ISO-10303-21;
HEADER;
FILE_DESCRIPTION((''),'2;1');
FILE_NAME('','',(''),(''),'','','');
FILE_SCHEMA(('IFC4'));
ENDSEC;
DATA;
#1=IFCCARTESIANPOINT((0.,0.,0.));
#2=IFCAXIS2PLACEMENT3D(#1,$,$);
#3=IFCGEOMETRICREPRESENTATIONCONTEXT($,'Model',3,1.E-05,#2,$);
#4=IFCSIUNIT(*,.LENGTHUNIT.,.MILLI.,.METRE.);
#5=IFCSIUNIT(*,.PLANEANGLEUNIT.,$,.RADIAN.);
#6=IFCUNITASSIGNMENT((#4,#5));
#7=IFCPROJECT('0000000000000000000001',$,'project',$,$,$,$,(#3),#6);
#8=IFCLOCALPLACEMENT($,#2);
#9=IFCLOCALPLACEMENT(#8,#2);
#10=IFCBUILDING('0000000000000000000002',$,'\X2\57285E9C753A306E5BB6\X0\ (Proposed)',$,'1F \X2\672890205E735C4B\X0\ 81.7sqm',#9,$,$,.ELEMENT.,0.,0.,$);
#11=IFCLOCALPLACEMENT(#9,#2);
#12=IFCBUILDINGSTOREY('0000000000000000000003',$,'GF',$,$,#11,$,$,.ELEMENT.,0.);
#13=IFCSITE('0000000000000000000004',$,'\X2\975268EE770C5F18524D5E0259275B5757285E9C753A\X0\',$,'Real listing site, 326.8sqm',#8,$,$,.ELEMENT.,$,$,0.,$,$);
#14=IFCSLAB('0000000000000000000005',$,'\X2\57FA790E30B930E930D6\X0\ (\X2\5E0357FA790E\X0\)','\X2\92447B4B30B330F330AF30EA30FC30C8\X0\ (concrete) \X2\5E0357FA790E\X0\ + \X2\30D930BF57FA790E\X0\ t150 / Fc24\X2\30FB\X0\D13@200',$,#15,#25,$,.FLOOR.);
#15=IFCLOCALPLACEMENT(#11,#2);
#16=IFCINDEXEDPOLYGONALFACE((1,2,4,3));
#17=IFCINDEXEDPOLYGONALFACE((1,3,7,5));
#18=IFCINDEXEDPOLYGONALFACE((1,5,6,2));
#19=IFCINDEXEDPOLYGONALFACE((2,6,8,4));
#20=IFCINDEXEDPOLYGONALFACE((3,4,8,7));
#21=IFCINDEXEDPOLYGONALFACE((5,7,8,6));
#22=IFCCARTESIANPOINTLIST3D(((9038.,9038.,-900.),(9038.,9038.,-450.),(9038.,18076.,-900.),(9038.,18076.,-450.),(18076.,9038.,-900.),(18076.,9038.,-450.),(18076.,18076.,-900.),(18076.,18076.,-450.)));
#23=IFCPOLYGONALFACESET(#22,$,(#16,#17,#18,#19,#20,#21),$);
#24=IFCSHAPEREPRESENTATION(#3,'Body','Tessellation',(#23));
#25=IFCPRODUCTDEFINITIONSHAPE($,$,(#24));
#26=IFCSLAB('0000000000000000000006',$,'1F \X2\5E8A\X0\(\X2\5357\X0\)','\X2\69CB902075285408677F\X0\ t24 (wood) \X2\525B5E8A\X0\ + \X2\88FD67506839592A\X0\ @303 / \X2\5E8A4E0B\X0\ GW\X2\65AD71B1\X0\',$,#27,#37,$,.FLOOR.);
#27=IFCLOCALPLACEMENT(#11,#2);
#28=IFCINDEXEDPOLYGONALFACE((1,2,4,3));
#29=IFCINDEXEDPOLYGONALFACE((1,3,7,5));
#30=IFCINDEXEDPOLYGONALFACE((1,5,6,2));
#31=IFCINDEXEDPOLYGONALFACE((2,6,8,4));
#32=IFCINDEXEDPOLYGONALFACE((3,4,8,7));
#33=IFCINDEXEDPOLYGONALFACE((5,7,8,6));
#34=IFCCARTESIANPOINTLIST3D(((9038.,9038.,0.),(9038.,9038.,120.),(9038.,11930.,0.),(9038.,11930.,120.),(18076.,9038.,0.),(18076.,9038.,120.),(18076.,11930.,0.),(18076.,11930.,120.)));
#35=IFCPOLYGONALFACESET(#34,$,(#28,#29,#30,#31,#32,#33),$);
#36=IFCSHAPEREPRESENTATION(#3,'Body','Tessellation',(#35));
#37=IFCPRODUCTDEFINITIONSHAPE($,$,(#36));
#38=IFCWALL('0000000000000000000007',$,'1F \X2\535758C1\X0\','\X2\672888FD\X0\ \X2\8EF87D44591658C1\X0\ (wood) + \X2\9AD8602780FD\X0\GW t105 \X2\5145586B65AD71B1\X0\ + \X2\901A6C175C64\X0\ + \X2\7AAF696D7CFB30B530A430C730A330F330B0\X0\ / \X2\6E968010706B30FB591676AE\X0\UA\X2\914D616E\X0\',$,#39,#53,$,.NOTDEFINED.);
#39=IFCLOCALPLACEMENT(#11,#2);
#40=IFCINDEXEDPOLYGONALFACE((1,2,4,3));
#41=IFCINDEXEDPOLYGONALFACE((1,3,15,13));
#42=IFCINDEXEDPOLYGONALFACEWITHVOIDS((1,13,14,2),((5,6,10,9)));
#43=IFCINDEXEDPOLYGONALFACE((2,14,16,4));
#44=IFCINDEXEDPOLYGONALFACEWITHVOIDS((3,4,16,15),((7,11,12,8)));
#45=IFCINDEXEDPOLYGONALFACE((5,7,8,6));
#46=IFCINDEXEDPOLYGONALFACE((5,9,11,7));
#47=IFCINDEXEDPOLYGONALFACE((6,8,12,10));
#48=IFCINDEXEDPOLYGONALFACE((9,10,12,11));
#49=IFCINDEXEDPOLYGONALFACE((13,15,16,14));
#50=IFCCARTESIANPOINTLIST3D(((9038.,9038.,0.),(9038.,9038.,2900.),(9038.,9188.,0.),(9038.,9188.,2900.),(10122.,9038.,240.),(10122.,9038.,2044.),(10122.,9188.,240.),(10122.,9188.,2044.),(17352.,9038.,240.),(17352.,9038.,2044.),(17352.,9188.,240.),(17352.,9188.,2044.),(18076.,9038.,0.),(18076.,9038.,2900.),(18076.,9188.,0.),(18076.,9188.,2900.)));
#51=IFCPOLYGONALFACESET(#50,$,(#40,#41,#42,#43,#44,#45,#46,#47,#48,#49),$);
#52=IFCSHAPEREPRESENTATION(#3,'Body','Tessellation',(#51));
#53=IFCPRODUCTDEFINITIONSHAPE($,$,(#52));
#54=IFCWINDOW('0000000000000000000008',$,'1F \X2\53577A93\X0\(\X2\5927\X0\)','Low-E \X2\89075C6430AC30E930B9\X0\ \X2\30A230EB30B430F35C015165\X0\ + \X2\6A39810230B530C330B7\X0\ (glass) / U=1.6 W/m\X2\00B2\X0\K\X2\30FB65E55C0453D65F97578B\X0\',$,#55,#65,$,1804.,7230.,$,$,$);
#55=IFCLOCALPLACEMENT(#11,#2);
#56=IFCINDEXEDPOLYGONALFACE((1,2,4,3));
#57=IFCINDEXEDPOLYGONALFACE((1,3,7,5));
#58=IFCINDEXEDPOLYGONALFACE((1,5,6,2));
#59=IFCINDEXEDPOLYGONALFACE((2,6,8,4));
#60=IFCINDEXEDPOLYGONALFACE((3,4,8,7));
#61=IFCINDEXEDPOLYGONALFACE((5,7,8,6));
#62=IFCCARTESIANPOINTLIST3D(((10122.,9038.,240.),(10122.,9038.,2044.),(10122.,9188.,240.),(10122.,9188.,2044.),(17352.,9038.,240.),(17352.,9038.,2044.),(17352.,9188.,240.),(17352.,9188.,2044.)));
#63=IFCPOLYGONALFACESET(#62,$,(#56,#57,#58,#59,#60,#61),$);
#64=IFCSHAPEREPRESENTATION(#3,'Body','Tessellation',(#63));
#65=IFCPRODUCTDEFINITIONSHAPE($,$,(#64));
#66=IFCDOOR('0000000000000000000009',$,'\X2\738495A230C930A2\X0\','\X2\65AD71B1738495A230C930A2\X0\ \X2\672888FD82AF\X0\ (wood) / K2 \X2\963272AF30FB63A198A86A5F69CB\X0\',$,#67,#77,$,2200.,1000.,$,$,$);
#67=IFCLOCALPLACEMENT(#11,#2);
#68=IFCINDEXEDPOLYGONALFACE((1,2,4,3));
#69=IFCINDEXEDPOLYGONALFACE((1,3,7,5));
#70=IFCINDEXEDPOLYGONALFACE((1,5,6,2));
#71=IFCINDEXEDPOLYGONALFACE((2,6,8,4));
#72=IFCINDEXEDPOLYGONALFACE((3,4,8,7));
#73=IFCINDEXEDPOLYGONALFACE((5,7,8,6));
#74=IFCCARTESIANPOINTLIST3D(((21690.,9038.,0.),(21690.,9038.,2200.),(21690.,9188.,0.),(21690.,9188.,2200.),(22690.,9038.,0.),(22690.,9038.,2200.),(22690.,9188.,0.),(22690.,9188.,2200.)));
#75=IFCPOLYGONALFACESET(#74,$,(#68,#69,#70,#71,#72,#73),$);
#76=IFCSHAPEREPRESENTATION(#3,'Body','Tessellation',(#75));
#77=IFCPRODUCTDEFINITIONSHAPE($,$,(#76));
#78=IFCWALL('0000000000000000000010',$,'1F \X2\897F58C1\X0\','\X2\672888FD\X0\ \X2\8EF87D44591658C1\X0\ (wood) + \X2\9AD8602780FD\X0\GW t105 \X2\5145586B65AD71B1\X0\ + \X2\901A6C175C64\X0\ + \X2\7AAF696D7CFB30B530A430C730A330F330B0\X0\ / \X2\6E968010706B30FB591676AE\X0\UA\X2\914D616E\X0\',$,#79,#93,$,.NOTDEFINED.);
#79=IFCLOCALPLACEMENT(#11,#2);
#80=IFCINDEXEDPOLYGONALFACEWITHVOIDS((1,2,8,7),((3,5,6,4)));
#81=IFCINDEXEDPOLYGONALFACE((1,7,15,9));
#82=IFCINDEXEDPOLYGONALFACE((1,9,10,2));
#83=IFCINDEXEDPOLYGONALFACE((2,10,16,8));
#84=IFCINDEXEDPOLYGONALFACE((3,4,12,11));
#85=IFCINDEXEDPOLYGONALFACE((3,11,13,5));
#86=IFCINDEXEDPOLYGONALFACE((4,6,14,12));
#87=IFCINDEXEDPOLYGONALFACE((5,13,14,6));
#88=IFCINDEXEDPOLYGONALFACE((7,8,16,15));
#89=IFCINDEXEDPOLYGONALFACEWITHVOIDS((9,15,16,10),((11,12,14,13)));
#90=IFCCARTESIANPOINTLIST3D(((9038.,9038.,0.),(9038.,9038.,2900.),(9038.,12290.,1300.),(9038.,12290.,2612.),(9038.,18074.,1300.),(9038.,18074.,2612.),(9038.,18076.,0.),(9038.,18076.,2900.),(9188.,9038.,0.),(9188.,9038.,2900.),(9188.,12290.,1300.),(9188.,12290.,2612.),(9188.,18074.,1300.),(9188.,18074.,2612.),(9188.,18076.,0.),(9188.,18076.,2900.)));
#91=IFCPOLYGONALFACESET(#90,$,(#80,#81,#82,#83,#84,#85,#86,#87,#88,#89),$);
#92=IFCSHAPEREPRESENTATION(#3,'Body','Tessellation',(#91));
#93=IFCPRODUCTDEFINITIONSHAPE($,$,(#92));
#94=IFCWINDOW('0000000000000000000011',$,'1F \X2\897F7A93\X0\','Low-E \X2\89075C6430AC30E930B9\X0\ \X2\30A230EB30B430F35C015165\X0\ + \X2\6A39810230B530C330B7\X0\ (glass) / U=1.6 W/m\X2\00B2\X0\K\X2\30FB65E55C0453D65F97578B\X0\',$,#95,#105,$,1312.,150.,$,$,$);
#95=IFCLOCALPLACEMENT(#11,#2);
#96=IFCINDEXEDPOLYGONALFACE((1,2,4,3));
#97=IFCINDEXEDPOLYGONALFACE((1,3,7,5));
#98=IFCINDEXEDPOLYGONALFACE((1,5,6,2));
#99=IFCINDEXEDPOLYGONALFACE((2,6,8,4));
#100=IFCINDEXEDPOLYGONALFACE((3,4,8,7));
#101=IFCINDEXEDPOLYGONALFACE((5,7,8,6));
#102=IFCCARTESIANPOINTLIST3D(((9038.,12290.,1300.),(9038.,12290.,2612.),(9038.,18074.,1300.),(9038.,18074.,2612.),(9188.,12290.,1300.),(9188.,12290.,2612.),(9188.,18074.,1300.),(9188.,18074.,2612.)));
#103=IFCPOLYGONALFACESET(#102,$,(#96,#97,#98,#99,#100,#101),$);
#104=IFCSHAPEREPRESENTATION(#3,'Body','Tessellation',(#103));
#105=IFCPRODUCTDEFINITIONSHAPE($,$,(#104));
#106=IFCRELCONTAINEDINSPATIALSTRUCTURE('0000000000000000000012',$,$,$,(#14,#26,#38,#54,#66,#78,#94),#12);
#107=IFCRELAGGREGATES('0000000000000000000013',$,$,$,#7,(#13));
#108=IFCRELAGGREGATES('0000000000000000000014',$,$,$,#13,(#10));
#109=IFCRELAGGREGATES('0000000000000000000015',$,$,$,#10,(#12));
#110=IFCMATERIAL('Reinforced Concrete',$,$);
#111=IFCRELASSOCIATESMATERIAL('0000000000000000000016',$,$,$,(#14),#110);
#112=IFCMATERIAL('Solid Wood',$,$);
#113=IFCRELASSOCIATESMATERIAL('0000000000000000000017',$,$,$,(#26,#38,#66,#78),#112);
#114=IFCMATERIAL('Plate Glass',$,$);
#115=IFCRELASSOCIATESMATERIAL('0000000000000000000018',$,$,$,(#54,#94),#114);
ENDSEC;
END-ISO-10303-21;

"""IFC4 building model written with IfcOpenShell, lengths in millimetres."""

from ifc_helpers import new_model, si_unit, frame, frame_2d, origin, place, context, project, spatial, rectangle, extrude, material, element, fill, save


model = new_model("IFC4")

# Units and contexts
model_context = context("Model", 3, precision=1e-05, world=origin())
ifc_project = project(units=[si_unit("LENGTHUNIT", "METRE", prefix="MILLI"), si_unit("PLANEANGLEUNIT", "RADIAN")], contexts=[model_context])

# Site, building, storey
site_placement = place(None, origin())
site = spatial("IfcSite", under=ifc_project, at=site_placement, Name="青森県弘前市大字在府町", ObjectType="Real listing site, 326.8sqm", CompositionType="ELEMENT", RefElevation=0.0)
building_placement = place(site_placement, origin())
building = spatial("IfcBuilding", under=site, at=building_placement, Name="在府町の家 (Proposed)", ObjectType="1F 木造平屋 81.7sqm", CompositionType="ELEMENT", ElevationOfRefHeight=0.0, ElevationOfTerrain=0.0)
storey_placement = place(building_placement, origin())
storey = spatial("IfcBuildingStorey", under=building, at=storey_placement, Name="GF", CompositionType="ELEMENT", Elevation=0.0)

# Slabs
ifc_material_1 = material(Name="Reinforced Concrete")
slab_1_placement = place(storey_placement, frame((4519.0, 4519.0, -450.0)))
element("IfcSlab", 1, at=slab_1_placement, inside=storey, material=ifc_material_1, Name="基礎スラブ (布基礎)", Description="鉄筋コンクリート (concrete) 布基礎 + ベタ基礎 t150 / Fc24・D13@200", PredefinedType="FLOOR", context=model_context, shape_type="SweptSolid", body=[
    extrude(rectangle(XDim=9038.0, YDim=9038.0, at=frame_2d((4519.0, 4519.0))), frame((4519.0, 4519.0, -450.0)), (0.0, 0.0, 1.0), 450.0),
])
ifc_material_2 = material(Name="Solid Wood")
slab_2_placement = place(storey_placement, frame((4519.0, 4519.0, 0.0)))
element("IfcSlab", 2, at=slab_2_placement, inside=storey, material=ifc_material_2, Name="1F 床(南)", Description="構造用合板 t24 (wood) 剛床 + 製材根太 @303 / 床下 GW断熱", PredefinedType="FLOOR", context=model_context, shape_type="SweptSolid", body=[
    extrude(rectangle(XDim=9038.0, YDim=2892.0, at=frame_2d((4519.0, 1446.0))), frame((4519.0, 4519.0, 0.0)), (0.0, 0.0, 1.0), 120.0),
])

# Wall, openings, window, door
wall_1_placement = place(storey_placement, frame((4519.0, 4519.0, 0.0)))
wall_1 = element("IfcWall", 3, at=wall_1_placement, inside=storey, material=ifc_material_2, Name="1F 南壁", Description="木製 軸組外壁 (wood) + 高性能GW t105 充填断熱 + 通気層 + 窯業系サイディング / 準耐火・外皮UA配慮", PredefinedType="NOTDEFINED", context=model_context, shape_type="SweptSolid", body=[
    extrude(rectangle(XDim=9038.0, YDim=150.0, at=frame_2d((4519.0, 75.0))), frame((4519.0, 4519.0, 0.0)), (0.0, 0.0, 1.0), 2900.0),
])
opening_1_placement = place(storey_placement, frame((5061.0, 4519.0, 120.0)))
opening_1 = element("IfcOpeningElement", 4, at=opening_1_placement, cuts=wall_1, PredefinedType="NOTDEFINED", context=model_context, shape_type="SweptSolid", body=[
    extrude(rectangle(XDim=7230.0, YDim=150.0, at=frame_2d((3615.0, 75.0))), frame((5061.0, 4519.0, 120.0)), (0.0, 0.0, 1.0), 1804.0),
])
opening_2_placement = place(storey_placement, frame((10845.0, 4519.0, 0.0)))
opening_2 = element("IfcOpeningElement", 5, at=opening_2_placement, cuts=wall_1, PredefinedType="NOTDEFINED", context=model_context, shape_type="SweptSolid", body=[
    extrude(rectangle(XDim=1000.0, YDim=150.0, at=frame_2d((500.0, 75.0))), frame((10845.0, 4519.0, 0.0)), (0.0, 0.0, 1.0), 2200.0),
])
ifc_material_3 = material(Name="Plate Glass")
window_1_placement = place(storey_placement, frame((5061.0, 4519.0, 120.0)))
window_1 = element("IfcWindow", 6, at=window_1_placement, inside=storey, material=ifc_material_3, Name="1F 南窓(大)", Description="Low-E 複層ガラス アルゴン封入 + 樹脂サッシ (glass) / U=1.6 W/m²K・日射取得型", OverallHeight=1804.0, OverallWidth=7230.0, context=model_context, shape_type="SweptSolid", body=[
    extrude(rectangle(XDim=7230.0, YDim=150.0, at=frame_2d((3615.0, 75.0))), frame((5061.0, 4519.0, 120.0)), (0.0, 0.0, 1.0), 1804.0),
])
fill(opening_1, window_1)
door_1_placement = place(storey_placement, frame((10845.0, 4519.0, 0.0)))
door_1 = element("IfcDoor", 7, at=door_1_placement, inside=storey, material=ifc_material_2, Name="玄関ドア", Description="断熱玄関ドア 木製芯 (wood) / K2 防犯・採風機構", OverallHeight=2200.0, OverallWidth=1000.0, context=model_context, shape_type="SweptSolid", body=[
    extrude(rectangle(XDim=1000.0, YDim=150.0, at=frame_2d((500.0, 75.0))), frame((10845.0, 4519.0, 0.0)), (0.0, 0.0, 1.0), 2200.0),
])
fill(opening_2, door_1)

# Wall, opening, window
wall_2_placement = place(storey_placement, frame((4519.0, 4519.0, 0.0)))
wall_2 = element("IfcWall", 8, at=wall_2_placement, inside=storey, material=ifc_material_2, Name="1F 西壁", Description="木製 軸組外壁 (wood) + 高性能GW t105 充填断熱 + 通気層 + 窯業系サイディング / 準耐火・外皮UA配慮", PredefinedType="NOTDEFINED", context=model_context, shape_type="SweptSolid", body=[
    extrude(rectangle(XDim=150.0, YDim=9038.0, at=frame_2d((75.0, 4519.0))), frame((4519.0, 4519.0, 0.0)), (0.0, 0.0, 1.0), 2900.0),
])
opening_3_placement = place(storey_placement, frame((4519.0, 6145.0, 650.0)))
opening_3 = element("IfcOpeningElement", 9, at=opening_3_placement, cuts=wall_2, PredefinedType="NOTDEFINED", context=model_context, shape_type="SweptSolid", body=[
    extrude(rectangle(XDim=150.0, YDim=5784.0, at=frame_2d((75.0, 2892.0))), frame((4519.0, 6145.0, 650.0)), (0.0, 0.0, 1.0), 1312.0),
])
window_2_placement = place(storey_placement, frame((4519.0, 6145.0, 650.0)))
window_2 = element("IfcWindow", 10, at=window_2_placement, inside=storey, material=ifc_material_3, Name="1F 西窓", Description="Low-E 複層ガラス アルゴン封入 + 樹脂サッシ (glass) / U=1.6 W/m²K・日射取得型", OverallHeight=1312.0, OverallWidth=150.0, context=model_context, shape_type="SweptSolid", body=[
    extrude(rectangle(XDim=150.0, YDim=5784.0, at=frame_2d((75.0, 2892.0))), frame((4519.0, 6145.0, 650.0)), (0.0, 0.0, 1.0), 1312.0),
])
fill(opening_3, window_2)

save(model, "model.ifc")
